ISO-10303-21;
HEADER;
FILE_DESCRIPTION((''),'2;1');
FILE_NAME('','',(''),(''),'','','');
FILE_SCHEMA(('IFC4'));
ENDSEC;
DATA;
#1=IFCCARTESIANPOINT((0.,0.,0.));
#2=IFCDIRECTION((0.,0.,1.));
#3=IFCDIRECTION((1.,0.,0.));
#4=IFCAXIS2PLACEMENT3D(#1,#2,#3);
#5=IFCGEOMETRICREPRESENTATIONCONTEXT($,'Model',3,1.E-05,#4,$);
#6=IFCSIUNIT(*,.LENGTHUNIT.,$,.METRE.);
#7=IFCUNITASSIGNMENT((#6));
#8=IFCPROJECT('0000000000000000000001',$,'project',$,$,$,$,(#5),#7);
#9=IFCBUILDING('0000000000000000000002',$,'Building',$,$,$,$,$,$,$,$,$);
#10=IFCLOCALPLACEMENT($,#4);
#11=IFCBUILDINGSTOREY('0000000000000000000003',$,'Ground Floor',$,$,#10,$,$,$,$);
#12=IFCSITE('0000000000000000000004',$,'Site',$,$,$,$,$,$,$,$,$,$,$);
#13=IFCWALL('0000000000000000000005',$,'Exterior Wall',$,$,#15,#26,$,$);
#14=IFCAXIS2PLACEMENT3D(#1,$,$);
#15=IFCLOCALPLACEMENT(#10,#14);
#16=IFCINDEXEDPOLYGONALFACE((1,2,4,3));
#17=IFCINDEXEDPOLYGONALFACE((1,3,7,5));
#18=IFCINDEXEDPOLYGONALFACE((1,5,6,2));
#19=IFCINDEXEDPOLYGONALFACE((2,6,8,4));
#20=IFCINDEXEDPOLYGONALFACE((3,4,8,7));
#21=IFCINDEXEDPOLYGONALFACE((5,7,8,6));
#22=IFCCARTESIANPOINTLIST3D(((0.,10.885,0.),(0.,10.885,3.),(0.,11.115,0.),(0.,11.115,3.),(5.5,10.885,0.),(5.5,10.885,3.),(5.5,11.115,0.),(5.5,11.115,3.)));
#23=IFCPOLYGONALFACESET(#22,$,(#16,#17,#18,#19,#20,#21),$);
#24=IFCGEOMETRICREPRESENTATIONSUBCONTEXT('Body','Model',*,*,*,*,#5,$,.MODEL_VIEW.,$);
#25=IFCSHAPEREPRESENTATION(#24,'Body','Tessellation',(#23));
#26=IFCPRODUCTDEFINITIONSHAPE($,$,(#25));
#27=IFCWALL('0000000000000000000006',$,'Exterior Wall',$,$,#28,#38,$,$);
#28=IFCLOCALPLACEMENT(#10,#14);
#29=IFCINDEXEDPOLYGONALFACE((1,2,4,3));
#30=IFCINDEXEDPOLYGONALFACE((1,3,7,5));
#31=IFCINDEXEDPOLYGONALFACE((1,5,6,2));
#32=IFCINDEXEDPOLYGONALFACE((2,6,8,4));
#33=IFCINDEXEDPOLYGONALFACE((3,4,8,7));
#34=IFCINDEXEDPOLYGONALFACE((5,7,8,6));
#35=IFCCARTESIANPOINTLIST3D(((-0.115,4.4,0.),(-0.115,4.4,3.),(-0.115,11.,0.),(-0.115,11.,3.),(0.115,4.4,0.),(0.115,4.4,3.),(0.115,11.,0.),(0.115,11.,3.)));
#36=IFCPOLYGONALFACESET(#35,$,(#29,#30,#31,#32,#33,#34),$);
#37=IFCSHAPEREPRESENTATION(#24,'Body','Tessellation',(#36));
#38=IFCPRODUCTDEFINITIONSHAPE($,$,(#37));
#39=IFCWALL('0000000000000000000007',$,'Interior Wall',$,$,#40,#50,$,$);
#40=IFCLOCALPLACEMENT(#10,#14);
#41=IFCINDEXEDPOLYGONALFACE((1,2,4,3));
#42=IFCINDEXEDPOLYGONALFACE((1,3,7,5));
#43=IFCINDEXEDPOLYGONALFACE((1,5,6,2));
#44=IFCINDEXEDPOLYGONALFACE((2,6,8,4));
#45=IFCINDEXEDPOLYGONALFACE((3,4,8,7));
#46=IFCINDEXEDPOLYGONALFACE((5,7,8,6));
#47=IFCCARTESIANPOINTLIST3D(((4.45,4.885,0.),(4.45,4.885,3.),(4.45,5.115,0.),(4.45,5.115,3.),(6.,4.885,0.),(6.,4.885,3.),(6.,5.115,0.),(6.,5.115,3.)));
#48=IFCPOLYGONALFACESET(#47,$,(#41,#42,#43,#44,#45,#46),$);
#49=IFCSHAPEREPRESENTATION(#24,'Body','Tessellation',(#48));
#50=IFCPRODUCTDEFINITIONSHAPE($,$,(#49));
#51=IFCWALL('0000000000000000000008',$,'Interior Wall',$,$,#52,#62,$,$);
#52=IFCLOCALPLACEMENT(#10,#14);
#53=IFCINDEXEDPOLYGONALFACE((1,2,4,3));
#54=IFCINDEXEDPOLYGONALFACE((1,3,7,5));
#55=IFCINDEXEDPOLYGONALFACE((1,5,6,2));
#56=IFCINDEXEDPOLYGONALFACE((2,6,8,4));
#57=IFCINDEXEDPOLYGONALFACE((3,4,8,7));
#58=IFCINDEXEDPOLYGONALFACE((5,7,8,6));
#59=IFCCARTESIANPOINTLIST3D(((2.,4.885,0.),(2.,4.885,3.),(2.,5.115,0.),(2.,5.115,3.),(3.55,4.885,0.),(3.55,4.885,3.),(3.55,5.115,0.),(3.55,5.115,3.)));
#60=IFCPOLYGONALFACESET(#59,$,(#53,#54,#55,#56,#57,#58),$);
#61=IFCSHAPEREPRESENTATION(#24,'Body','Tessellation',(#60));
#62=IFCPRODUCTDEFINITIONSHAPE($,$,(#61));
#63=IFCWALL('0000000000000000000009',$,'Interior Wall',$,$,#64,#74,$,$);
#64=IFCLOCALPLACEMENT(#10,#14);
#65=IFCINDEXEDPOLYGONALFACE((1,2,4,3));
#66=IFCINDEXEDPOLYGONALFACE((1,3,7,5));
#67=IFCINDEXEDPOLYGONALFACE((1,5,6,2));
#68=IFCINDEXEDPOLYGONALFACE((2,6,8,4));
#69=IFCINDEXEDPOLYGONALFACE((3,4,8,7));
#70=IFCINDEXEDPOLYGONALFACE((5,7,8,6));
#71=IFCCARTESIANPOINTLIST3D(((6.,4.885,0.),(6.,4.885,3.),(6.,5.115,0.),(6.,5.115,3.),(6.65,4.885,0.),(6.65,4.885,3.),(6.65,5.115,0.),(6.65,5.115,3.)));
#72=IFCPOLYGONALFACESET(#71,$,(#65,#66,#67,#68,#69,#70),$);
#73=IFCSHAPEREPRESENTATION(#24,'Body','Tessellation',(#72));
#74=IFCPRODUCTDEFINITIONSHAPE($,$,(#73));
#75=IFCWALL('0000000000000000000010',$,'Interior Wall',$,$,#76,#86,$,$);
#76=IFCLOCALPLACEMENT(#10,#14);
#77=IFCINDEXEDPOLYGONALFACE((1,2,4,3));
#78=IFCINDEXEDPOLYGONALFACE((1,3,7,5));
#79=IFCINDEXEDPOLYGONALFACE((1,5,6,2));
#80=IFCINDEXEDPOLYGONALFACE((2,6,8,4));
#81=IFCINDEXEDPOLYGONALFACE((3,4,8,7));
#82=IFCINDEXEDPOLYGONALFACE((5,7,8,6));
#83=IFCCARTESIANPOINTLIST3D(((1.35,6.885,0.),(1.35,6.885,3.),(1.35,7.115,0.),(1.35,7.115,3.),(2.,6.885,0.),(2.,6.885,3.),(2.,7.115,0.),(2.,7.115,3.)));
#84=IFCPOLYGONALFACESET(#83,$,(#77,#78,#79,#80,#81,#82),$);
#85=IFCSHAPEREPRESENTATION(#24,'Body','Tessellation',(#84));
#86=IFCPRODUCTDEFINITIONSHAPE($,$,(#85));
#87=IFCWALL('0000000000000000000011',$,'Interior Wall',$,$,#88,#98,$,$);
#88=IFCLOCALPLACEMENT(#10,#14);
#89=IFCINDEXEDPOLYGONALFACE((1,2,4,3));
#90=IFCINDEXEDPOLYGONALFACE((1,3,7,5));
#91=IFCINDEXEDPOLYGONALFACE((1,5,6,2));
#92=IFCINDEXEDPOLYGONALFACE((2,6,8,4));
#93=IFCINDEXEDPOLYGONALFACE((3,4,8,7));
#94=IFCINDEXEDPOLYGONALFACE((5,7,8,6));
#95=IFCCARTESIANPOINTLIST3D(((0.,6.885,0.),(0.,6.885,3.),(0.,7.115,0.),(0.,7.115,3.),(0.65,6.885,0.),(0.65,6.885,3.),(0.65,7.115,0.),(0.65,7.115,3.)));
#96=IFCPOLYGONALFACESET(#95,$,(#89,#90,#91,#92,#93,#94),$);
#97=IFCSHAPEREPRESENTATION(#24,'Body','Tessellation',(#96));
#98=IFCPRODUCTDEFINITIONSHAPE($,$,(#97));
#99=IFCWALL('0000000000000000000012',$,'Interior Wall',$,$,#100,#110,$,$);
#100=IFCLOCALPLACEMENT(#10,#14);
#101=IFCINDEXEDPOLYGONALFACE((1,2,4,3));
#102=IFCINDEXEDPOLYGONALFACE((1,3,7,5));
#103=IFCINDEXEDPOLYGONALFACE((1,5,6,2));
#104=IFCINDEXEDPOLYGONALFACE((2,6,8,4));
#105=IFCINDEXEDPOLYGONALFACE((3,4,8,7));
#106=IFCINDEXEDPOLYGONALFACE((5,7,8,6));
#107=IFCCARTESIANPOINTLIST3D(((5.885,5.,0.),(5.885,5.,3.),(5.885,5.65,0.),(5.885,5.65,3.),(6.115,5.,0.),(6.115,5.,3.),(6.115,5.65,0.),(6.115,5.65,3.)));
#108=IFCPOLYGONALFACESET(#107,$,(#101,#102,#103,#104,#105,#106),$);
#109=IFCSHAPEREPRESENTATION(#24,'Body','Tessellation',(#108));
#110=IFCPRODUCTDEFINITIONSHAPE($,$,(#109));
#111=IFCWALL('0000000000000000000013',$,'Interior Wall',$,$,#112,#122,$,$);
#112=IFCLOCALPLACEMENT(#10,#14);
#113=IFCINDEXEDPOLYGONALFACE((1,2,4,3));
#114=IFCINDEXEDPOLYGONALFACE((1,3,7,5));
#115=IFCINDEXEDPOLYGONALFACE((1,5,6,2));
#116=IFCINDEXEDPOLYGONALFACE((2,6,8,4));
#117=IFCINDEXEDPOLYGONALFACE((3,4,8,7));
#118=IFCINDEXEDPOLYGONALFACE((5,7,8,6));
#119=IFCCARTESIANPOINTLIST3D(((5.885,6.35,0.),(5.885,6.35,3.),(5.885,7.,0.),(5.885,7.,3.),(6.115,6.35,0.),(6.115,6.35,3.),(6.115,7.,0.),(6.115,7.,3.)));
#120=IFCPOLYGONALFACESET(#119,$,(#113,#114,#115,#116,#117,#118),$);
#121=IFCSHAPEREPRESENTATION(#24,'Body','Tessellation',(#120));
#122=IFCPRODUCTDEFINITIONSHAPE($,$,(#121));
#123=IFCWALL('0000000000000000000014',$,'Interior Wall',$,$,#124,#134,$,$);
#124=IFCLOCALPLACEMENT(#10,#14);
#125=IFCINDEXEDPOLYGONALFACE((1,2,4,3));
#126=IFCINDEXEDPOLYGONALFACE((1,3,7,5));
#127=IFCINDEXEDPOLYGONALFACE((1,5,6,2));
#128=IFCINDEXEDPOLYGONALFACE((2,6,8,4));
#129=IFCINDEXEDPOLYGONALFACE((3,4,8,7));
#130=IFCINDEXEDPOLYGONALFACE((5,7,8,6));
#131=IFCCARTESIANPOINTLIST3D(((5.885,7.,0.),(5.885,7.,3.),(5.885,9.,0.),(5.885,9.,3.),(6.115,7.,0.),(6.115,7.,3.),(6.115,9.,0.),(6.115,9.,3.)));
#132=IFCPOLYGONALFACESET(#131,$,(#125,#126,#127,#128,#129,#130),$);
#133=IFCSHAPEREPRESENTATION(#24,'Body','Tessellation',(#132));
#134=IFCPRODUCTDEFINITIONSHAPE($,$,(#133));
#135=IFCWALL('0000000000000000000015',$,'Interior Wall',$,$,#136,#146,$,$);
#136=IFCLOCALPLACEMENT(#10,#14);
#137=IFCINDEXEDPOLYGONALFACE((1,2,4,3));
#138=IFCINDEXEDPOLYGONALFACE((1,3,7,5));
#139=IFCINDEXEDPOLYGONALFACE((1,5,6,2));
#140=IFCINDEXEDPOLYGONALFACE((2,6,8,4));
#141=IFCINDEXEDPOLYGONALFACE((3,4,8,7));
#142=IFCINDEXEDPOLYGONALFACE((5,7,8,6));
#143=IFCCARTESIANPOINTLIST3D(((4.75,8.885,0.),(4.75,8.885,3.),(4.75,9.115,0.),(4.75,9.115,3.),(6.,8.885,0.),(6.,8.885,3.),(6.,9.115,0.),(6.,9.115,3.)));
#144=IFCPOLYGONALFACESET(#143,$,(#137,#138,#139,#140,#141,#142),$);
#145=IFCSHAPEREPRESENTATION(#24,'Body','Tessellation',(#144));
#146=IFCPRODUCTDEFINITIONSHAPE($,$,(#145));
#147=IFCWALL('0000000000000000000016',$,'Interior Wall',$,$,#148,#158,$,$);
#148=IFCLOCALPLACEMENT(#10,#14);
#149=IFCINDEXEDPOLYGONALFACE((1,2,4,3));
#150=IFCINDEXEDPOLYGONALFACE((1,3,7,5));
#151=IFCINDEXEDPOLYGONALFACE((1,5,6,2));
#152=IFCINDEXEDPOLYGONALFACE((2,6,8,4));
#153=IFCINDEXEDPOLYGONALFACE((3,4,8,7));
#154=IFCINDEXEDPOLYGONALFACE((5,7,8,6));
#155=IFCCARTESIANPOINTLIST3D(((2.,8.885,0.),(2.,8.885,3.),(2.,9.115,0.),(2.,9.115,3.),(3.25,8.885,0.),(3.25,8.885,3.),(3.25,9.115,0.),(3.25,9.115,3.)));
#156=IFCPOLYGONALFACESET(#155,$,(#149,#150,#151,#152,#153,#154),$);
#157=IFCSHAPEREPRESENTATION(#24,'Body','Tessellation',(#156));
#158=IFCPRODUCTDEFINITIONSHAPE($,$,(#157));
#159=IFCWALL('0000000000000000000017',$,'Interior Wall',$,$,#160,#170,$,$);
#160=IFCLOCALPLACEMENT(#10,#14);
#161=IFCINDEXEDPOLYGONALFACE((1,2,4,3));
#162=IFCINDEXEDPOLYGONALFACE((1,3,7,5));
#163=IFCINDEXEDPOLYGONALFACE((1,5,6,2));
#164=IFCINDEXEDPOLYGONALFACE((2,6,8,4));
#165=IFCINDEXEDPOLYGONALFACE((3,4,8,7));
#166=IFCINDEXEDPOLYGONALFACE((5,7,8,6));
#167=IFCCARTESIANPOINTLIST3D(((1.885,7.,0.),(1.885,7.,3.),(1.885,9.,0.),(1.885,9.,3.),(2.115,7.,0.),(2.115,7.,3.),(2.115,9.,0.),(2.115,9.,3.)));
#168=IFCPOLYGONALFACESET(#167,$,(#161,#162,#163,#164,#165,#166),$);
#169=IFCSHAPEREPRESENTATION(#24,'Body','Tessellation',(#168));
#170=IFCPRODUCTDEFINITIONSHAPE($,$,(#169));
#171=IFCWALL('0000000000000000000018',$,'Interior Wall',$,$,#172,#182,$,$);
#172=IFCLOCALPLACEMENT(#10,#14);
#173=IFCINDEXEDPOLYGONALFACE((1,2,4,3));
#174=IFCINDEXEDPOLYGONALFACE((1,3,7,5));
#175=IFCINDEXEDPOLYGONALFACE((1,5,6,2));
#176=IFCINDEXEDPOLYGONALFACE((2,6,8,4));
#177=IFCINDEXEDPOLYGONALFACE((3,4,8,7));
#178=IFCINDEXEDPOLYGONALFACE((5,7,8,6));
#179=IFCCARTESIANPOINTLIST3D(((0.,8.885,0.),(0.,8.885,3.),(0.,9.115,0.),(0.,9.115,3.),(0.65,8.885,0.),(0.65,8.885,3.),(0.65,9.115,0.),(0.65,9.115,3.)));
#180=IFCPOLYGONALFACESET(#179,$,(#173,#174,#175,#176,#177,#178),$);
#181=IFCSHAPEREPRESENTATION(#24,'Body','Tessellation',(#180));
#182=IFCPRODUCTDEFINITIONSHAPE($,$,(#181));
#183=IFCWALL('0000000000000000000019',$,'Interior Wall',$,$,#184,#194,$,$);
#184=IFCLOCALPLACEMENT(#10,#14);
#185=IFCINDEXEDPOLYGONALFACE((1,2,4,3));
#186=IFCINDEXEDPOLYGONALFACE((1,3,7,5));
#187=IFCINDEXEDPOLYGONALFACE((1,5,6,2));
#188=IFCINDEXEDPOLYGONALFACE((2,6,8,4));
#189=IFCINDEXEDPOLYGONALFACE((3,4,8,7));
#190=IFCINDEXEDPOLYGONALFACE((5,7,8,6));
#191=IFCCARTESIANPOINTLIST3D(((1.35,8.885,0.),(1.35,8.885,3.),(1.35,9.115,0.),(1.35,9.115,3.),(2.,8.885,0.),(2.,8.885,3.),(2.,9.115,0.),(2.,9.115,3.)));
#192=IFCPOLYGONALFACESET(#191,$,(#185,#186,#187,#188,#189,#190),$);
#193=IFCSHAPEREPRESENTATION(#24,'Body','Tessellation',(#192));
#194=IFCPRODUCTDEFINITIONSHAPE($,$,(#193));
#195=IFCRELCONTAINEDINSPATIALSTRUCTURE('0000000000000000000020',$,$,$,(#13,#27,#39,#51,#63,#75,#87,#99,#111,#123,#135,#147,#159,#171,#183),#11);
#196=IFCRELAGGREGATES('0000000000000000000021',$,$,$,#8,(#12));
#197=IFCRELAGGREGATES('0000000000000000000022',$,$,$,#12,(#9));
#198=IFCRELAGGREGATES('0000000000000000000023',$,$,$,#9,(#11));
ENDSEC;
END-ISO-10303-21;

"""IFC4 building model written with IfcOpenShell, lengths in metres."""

from ifc_helpers import new_model, si_unit, frame, origin_with_axes, place, context, subcontext, project, spatial, indexed_curve, outline, extrude, element, save


model = new_model("IFC4")

# Units and contexts
model_context = context("Model", 3, precision=1e-05, world=origin_with_axes())
body_context = subcontext(model_context, "Body", "Model", "MODEL_VIEW")
ifc_project = project(units=[si_unit("LENGTHUNIT", "METRE")], contexts=[model_context])

# Site, building, storey
site = spatial("IfcSite", under=ifc_project, Name="Site")
building = spatial("IfcBuilding", under=site, Name="Building")
storey_placement = place(None, origin_with_axes())
storey = spatial("IfcBuildingStorey", under=building, at=storey_placement, Name="Ground Floor")

# Walls
wall_1_placement = place(storey_placement, frame((5.5, 11.0, 0.0), z_axis=(0.0, 0.0, 1.0), x_axis=(-1.0, 0.0, 0.0)))
element("IfcWall", 1, at=wall_1_placement, inside=storey, Name="Exterior Wall", context=body_context, shape_type="SweptSolid", body=[
    extrude(outline(indexed_curve([(0.0, 0.0), (0.0, 0.23), (5.5, 0.23), (5.5, 0.0), (0.0, 0.0)], self_intersect=False)), frame((0.0, -0.115, 0.0), z_axis=(0.0, 0.0, 1.0), x_axis=(1.0, 0.0, 0.0)), (0.0, 0.0, 1.0), 3.0),
])
wall_2_placement = place(storey_placement, frame((0.0, 11.0, 0.0), z_axis=(0.0, 0.0, 1.0), x_axis=(0.0, -1.0, 0.0)))
element("IfcWall", 2, at=wall_2_placement, inside=storey, Name="Exterior Wall", context=body_context, shape_type="SweptSolid", body=[
    extrude(outline(indexed_curve([(0.0, 0.0), (0.0, 0.23), (6.6, 0.23), (6.6, 0.0), (0.0, 0.0)], self_intersect=False)), frame((0.0, -0.115, 0.0), z_axis=(0.0, 0.0, 1.0), x_axis=(1.0, 0.0, 0.0)), (0.0, 0.0, 1.0), 3.0),
])
for number, where, z_axis, x_axis, name in (
    (3, (6.0, 5.0, 0.0), (0.0, 0.0, 1.0), (-1.0, 0.0, 0.0), "Interior Wall"),
    (4, (3.55, 5.0, 0.0), (0.0, 0.0, 1.0), (-1.0, 0.0, 0.0), "Interior Wall"),
):
    element("IfcWall", number, at=place(storey_placement, frame(where, z_axis=z_axis, x_axis=x_axis)), inside=storey, Name=name, context=body_context, shape_type="SweptSolid", body=[
        extrude(outline(indexed_curve([(0.0, 0.0), (0.0, 0.23), (1.55, 0.23), (1.55, 0.0), (0.0, 0.0)], self_intersect=False)), frame((0.0, -0.115, 0.0), z_axis=(0.0, 0.0, 1.0), x_axis=(1.0, 0.0, 0.0)), (0.0, 0.0, 1.0), 3.0),
    ])
wall_3_placement = place(storey_placement, frame((6.65, 5.0, 0.0), z_axis=(0.0, 0.0, 1.0), x_axis=(-1.0, 0.0, 0.0)))
element("IfcWall", 5, at=wall_3_placement, inside=storey, Name="Interior Wall", context=body_context, shape_type="SweptSolid", body=[
    extrude(outline(indexed_curve([(0.0, 0.0), (0.0, 0.23), (0.65, 0.23), (0.65, 0.0), (0.0, 0.0)], self_intersect=False)), frame((0.0, -0.115, 0.0), z_axis=(0.0, 0.0, 1.0), x_axis=(1.0, 0.0, 0.0)), (0.0, 0.0, 1.0), 3.0),
])
for number, where, z_axis, x_axis, name in (
    (6, (2.0, 7.0, 0.0), (0.0, 0.0, 1.0), (-1.0, 0.0, 0.0), "Interior Wall"),
    (7, (0.65, 7.0, 0.0), (0.0, 0.0, 1.0), (-1.0, 0.0, 0.0), "Interior Wall"),
):
    element("IfcWall", number, at=place(storey_placement, frame(where, z_axis=z_axis, x_axis=x_axis)), inside=storey, Name=name, context=body_context, shape_type="SweptSolid", body=[
        extrude(outline(indexed_curve([(0.0, 0.0), (0.0, 0.23), (0.65, 0.23), (0.65, 0.0), (0.0, 0.0)], self_intersect=False)), frame((0.0, -0.115, 0.0), z_axis=(0.0, 0.0, 1.0), x_axis=(1.0, 0.0, 0.0)), (0.0, 0.0, 1.0), 3.0),
    ])
for number, where, z_axis, x_axis, name in (
    (8, (6.0, 5.0, 0.0), (0.0, 0.0, 1.0), (0.0, 1.0, 0.0), "Interior Wall"),
    (9, (6.0, 6.35, 0.0), (0.0, 0.0, 1.0), (0.0, 1.0, 0.0), "Interior Wall"),
):
    element("IfcWall", number, at=place(storey_placement, frame(where, z_axis=z_axis, x_axis=x_axis)), inside=storey, Name=name, context=body_context, shape_type="SweptSolid", body=[
        extrude(outline(indexed_curve([(0.0, 0.0), (0.0, 0.23), (0.65, 0.23), (0.65, 0.0), (0.0, 0.0)], self_intersect=False)), frame((0.0, -0.115, 0.0), z_axis=(0.0, 0.0, 1.0), x_axis=(1.0, 0.0, 0.0)), (0.0, 0.0, 1.0), 3.0),
    ])
wall_4_placement = place(storey_placement, frame((6.0, 7.0, 0.0), z_axis=(0.0, 0.0, 1.0), x_axis=(0.0, 1.0, 0.0)))
element("IfcWall", 10, at=wall_4_placement, inside=storey, Name="Interior Wall", context=body_context, shape_type="SweptSolid", body=[
    extrude(outline(indexed_curve([(0.0, 0.0), (0.0, 0.23), (2.0, 0.23), (2.0, 0.0), (0.0, 0.0)], self_intersect=False)), frame((0.0, -0.115, 0.0), z_axis=(0.0, 0.0, 1.0), x_axis=(1.0, 0.0, 0.0)), (0.0, 0.0, 1.0), 3.0),
])
for number, where, z_axis, x_axis, name in (
    (11, (6.0, 9.0, 0.0), (0.0, 0.0, 1.0), (-1.0, 0.0, 0.0), "Interior Wall"),
    (12, (3.25, 9.0, 0.0), (0.0, 0.0, 1.0), (-1.0, 0.0, 0.0), "Interior Wall"),
):
    element("IfcWall", number, at=place(storey_placement, frame(where, z_axis=z_axis, x_axis=x_axis)), inside=storey, Name=name, context=body_context, shape_type="SweptSolid", body=[
        extrude(outline(indexed_curve([(0.0, 0.0), (0.0, 0.23), (1.25, 0.23), (1.25, 0.0), (0.0, 0.0)], self_intersect=False)), frame((0.0, -0.115, 0.0), z_axis=(0.0, 0.0, 1.0), x_axis=(1.0, 0.0, 0.0)), (0.0, 0.0, 1.0), 3.0),
    ])
wall_5_placement = place(storey_placement, frame((2.0, 9.0, 0.0), z_axis=(0.0, 0.0, 1.0), x_axis=(0.0, -1.0, 0.0)))
element("IfcWall", 13, at=wall_5_placement, inside=storey, Name="Interior Wall", context=body_context, shape_type="SweptSolid", body=[
    extrude(outline(indexed_curve([(0.0, 0.0), (0.0, 0.23), (2.0, 0.23), (2.0, 0.0), (0.0, 0.0)], self_intersect=False)), frame((0.0, -0.115, 0.0), z_axis=(0.0, 0.0, 1.0), x_axis=(1.0, 0.0, 0.0)), (0.0, 0.0, 1.0), 3.0),
])
wall_6_placement = place(storey_placement, frame((0.0, 9.0, 0.0), z_axis=(0.0, 0.0, 1.0), x_axis=(1.0, 0.0, 0.0)))
element("IfcWall", 14, at=wall_6_placement, inside=storey, Name="Interior Wall", context=body_context, shape_type="SweptSolid", body=[
    extrude(outline(indexed_curve([(0.0, 0.0), (0.0, 0.23), (0.65, 0.23), (0.65, 0.0), (0.0, 0.0)], self_intersect=False)), frame((0.0, -0.115, 0.0), z_axis=(0.0, 0.0, 1.0), x_axis=(1.0, 0.0, 0.0)), (0.0, 0.0, 1.0), 3.0),
])
wall_7_placement = place(storey_placement, frame((1.35, 9.0, 0.0), z_axis=(0.0, 0.0, 1.0), x_axis=(1.0, 0.0, 0.0)))
element("IfcWall", 15, at=wall_7_placement, inside=storey, Name="Interior Wall", context=body_context, shape_type="SweptSolid", body=[
    extrude(outline(indexed_curve([(0.0, 0.0), (0.0, 0.23), (0.65, 0.23), (0.65, 0.0), (0.0, 0.0)], self_intersect=False)), frame((0.0, -0.115, 0.0), z_axis=(0.0, 0.0, 1.0), x_axis=(1.0, 0.0, 0.0)), (0.0, 0.0, 1.0), 3.0),
])

save(model, "model.ifc")
